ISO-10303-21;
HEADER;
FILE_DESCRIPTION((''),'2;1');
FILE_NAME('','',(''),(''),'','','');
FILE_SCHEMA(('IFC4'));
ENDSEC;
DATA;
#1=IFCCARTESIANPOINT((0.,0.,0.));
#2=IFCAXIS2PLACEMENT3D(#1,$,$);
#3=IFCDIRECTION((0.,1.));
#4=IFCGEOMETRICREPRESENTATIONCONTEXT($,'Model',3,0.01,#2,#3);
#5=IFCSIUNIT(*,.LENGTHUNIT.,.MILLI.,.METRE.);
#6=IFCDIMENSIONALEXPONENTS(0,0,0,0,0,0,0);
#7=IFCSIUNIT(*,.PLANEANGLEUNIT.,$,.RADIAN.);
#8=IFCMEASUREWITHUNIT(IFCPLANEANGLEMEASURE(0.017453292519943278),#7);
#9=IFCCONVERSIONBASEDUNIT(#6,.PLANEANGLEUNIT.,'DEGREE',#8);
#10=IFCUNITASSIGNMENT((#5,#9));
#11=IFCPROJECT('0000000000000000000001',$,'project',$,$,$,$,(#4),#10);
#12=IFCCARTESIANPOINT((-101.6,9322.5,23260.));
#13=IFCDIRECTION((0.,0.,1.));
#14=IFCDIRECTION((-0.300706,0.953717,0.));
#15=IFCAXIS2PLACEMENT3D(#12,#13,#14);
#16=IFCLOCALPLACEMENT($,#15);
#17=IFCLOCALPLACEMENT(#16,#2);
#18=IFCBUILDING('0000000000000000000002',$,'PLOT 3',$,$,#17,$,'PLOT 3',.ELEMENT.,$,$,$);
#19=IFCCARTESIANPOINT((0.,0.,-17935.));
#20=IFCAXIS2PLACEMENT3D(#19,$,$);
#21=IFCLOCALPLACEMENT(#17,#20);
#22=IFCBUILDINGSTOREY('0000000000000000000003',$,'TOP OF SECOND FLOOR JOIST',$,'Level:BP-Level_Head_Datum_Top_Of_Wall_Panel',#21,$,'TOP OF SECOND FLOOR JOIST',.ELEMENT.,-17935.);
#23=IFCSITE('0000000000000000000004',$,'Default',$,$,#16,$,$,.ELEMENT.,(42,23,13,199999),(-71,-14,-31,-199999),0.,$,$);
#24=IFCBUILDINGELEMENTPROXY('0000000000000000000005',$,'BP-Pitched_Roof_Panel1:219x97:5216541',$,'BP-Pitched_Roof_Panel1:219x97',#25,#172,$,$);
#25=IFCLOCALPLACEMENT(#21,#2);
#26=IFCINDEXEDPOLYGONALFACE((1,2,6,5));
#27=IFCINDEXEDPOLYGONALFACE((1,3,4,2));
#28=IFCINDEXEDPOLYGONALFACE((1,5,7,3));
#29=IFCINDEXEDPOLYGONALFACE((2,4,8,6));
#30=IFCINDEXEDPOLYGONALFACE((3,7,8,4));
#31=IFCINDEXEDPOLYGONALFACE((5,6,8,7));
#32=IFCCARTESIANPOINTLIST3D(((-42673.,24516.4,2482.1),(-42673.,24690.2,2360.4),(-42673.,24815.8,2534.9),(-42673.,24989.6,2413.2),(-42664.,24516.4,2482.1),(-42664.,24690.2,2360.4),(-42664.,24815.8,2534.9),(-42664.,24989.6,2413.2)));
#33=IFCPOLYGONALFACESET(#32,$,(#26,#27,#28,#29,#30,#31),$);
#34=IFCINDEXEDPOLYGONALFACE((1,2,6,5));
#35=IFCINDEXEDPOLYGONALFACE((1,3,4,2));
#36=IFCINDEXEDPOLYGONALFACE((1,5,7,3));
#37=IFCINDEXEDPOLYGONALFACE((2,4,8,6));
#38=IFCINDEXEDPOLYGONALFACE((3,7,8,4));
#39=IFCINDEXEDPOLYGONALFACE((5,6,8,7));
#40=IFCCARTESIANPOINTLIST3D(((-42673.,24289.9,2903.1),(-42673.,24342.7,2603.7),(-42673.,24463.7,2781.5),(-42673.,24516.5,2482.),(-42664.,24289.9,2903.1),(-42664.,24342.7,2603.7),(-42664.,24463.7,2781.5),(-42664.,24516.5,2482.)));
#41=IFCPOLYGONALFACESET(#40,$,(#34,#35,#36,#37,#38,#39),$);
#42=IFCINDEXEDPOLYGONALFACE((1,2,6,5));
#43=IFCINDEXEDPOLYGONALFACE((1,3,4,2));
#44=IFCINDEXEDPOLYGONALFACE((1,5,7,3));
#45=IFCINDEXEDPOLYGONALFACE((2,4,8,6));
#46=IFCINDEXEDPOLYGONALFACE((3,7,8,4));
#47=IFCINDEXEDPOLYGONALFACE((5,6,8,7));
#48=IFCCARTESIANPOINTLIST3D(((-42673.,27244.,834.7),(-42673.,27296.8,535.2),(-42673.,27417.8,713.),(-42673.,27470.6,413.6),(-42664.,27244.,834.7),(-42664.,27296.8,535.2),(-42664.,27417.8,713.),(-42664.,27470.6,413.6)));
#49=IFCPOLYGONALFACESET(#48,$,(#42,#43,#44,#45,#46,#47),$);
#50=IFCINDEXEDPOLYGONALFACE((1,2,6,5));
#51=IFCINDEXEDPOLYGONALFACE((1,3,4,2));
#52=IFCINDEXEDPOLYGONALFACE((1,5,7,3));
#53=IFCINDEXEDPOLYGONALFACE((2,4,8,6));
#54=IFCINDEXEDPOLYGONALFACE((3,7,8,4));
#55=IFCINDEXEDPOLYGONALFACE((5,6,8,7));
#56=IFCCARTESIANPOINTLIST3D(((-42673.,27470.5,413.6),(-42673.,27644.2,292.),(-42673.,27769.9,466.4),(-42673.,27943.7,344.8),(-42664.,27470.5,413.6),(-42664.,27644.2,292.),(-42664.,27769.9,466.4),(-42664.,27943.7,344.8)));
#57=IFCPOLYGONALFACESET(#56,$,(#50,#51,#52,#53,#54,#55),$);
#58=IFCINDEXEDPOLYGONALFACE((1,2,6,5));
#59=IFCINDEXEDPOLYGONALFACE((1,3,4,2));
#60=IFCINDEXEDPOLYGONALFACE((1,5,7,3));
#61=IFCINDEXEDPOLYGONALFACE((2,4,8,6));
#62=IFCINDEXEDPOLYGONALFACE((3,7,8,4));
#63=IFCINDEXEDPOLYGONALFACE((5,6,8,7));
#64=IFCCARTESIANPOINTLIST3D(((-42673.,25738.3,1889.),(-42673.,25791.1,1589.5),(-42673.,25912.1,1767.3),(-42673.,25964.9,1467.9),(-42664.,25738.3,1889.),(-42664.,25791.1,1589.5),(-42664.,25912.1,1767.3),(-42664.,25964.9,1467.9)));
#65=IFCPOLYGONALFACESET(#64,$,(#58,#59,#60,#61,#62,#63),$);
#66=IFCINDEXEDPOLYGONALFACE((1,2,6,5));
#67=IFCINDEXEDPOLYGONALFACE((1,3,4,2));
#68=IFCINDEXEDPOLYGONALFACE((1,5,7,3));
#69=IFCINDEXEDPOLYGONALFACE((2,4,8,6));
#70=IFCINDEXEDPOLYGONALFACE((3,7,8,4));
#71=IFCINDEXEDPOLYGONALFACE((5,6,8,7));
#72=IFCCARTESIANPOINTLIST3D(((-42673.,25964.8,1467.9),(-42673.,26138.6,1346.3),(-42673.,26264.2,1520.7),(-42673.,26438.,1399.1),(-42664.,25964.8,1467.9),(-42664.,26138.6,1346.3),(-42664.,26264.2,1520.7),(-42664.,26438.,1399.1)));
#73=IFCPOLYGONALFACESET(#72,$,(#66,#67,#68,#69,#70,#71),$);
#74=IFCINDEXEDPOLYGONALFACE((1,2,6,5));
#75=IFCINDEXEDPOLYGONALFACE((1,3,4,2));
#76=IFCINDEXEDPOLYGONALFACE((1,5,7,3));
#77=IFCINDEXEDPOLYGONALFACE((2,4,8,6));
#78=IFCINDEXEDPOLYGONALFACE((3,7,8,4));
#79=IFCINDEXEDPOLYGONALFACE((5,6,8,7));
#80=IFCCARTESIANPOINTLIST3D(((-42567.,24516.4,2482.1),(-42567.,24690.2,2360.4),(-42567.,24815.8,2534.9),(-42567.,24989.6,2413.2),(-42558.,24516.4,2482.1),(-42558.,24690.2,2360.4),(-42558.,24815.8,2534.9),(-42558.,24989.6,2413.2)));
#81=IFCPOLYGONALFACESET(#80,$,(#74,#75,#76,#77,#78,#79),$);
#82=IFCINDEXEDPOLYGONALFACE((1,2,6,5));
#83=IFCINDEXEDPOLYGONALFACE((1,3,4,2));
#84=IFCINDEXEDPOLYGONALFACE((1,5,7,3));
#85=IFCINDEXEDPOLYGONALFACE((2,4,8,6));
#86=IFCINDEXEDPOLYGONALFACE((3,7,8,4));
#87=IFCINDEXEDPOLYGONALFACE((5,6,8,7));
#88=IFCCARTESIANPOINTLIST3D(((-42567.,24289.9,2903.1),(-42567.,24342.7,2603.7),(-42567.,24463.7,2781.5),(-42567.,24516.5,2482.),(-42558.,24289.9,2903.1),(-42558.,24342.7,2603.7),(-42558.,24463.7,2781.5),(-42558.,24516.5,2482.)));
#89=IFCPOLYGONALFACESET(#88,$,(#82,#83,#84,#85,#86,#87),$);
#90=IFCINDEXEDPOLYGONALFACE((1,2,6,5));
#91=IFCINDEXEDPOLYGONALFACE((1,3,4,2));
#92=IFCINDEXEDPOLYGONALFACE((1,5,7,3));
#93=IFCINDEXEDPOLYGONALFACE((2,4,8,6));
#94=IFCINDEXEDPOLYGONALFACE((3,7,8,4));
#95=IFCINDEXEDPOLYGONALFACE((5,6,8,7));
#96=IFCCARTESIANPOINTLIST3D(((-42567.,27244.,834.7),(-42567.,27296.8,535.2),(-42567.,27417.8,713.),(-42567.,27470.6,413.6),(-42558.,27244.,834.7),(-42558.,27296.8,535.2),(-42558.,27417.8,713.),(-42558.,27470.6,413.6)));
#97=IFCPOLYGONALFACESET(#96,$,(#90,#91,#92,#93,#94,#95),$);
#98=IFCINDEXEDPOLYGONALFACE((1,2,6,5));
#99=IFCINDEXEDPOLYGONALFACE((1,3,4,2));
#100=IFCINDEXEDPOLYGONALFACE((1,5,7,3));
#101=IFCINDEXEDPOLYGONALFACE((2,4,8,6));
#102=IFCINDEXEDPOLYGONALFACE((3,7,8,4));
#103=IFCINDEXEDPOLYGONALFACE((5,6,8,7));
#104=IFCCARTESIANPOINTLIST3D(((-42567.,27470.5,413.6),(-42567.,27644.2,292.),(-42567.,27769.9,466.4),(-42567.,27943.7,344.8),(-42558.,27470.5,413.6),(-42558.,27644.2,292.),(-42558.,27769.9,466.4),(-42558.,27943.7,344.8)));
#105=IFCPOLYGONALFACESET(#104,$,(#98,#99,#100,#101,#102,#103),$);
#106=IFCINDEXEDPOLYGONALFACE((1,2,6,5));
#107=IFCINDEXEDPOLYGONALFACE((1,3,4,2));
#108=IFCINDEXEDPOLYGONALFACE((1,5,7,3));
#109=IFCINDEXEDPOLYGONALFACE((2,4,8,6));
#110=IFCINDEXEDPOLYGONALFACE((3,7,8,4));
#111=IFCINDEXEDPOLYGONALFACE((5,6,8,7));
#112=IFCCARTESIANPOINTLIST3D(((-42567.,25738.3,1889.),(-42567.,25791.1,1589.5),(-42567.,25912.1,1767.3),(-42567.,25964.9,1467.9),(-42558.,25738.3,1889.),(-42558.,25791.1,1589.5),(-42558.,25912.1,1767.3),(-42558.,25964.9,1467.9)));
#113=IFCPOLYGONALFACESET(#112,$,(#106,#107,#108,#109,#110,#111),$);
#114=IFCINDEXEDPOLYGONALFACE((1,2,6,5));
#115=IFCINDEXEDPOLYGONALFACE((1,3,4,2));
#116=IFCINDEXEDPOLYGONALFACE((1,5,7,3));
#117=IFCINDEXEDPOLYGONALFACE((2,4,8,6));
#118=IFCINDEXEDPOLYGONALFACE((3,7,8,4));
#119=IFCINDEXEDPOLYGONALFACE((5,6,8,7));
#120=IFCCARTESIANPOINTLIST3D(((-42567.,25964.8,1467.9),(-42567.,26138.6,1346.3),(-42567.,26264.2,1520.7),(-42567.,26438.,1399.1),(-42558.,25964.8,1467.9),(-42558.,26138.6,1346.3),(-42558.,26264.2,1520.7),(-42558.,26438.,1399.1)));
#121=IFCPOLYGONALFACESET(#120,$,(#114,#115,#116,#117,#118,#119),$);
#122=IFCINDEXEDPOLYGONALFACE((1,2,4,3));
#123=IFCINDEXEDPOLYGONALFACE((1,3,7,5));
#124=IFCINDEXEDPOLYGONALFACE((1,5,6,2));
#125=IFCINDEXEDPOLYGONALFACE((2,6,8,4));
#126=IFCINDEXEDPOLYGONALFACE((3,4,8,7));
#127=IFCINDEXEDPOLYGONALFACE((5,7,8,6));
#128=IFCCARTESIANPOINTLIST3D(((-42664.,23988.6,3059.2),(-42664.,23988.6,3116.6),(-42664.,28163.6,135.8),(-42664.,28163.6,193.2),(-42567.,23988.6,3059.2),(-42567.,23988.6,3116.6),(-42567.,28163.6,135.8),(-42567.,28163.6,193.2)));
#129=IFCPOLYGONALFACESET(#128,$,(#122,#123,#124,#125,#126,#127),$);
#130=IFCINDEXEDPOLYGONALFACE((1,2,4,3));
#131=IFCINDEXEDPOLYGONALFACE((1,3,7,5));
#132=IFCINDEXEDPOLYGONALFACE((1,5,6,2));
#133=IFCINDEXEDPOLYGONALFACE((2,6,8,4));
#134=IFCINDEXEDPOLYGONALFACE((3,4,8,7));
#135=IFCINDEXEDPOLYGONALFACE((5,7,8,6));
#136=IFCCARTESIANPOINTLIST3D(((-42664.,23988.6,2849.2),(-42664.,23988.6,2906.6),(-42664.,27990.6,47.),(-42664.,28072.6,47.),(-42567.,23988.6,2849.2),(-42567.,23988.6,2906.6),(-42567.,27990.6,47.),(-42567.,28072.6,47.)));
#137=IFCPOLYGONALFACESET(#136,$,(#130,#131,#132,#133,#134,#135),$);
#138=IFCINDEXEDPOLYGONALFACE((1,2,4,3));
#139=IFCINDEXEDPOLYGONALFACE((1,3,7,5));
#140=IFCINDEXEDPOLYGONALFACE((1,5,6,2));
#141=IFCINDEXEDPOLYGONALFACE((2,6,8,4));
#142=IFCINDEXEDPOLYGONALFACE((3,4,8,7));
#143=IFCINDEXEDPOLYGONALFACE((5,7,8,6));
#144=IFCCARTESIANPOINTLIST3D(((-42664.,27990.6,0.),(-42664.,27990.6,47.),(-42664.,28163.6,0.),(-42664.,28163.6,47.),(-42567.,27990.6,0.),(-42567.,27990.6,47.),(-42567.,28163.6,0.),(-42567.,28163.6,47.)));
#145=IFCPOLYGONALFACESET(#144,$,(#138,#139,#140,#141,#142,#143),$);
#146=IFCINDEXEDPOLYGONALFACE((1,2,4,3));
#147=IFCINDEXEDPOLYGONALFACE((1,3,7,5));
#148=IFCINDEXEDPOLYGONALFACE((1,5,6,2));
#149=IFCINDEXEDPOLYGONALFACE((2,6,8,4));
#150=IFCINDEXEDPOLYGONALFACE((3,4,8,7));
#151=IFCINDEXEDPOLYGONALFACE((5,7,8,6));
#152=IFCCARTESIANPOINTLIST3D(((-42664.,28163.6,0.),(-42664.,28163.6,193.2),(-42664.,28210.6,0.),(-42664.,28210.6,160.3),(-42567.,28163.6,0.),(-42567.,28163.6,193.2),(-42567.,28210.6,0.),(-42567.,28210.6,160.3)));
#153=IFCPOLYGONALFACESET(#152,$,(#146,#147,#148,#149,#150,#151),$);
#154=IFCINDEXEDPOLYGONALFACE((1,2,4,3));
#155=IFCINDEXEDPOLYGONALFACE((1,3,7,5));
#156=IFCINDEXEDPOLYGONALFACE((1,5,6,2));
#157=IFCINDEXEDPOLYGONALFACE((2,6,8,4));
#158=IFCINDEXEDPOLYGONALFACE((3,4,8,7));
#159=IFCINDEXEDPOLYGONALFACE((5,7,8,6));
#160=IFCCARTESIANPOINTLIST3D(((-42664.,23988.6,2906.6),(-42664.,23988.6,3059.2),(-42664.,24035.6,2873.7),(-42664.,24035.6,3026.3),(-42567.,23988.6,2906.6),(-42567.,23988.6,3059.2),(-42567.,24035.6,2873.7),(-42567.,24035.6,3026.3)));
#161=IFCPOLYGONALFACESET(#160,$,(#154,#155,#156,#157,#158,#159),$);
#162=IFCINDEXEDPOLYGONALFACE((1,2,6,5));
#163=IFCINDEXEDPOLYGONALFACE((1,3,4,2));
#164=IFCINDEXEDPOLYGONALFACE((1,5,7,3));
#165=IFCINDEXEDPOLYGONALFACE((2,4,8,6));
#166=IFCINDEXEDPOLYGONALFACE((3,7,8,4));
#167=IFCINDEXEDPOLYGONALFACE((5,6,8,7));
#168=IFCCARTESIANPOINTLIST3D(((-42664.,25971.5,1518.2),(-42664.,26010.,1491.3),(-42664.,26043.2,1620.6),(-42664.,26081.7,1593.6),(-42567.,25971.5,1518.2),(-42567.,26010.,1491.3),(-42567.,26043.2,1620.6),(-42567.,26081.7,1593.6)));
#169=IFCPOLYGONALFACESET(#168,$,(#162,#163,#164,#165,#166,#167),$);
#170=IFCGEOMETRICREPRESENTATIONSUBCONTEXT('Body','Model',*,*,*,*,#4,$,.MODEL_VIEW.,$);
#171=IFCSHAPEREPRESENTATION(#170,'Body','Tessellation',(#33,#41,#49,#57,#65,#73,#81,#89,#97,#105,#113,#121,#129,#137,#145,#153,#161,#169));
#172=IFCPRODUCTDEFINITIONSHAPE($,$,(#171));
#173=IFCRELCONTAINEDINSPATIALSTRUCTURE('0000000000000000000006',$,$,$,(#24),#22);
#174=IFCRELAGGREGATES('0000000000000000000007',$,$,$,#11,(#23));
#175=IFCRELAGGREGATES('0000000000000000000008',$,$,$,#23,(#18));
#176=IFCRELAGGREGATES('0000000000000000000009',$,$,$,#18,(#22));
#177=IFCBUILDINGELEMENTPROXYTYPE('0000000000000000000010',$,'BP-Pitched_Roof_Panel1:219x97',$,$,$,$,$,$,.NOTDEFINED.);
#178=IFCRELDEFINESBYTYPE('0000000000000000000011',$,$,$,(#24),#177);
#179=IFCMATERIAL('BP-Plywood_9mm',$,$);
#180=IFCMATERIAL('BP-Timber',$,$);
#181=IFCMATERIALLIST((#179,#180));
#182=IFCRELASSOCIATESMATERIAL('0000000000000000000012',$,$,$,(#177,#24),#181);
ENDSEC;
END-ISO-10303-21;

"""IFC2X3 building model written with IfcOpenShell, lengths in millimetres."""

from ifc_helpers import new_model, entity, si_unit, converted_unit, direction, frame, frame_2d, origin, origin_2d_with_axis, place, context, subcontext, project, spatial, polyline, rectangle, outline, extrude, source, transform, mapped, material, material_list, type_object, type_shapes, element, save


model = new_model("IFC2X3")

# Units and contexts
model_context = context("Model", 3, precision=0.01, world=origin(), true_north=direction((0.0, 1.0)))
body_context = subcontext(model_context, "Body", "Model", "MODEL_VIEW")
ifc_project = project(units=[si_unit("LENGTHUNIT", "METRE", prefix="MILLI"), converted_unit("PLANEANGLEUNIT", "DEGREE", entity("IfcPlaneAngleMeasure", 0.017453292519943278), si_unit("PLANEANGLEUNIT", "RADIAN"), dimensions=[0, 0, 0, 0, 0, 0, 0])], contexts=[model_context])

# Site, building, storey
site_placement = place(None, frame((-101.6, 9322.5, 23260.0), z_axis=(0.0, 0.0, 1.0), x_axis=(-0.300706, 0.953717, 0.0)))
site = spatial("IfcSite", under=ifc_project, at=site_placement, Name="Default", CompositionType="ELEMENT", RefLatitude=(42, 23, 13, 199999), RefLongitude=(-71, -14, -31, -199999), RefElevation=0.0)
building_placement = place(site_placement, origin())
building = spatial("IfcBuilding", under=site, at=building_placement, Name="PLOT 3", LongName="PLOT 3", CompositionType="ELEMENT")
storey_placement = place(building_placement, frame((0.0, 0.0, -17935.0)))
storey = spatial("IfcBuildingStorey", under=building, at=storey_placement, Name="TOP OF SECOND FLOOR JOIST", ObjectType="Level:BP-Level_Head_Datum_Top_Of_Wall_Panel", LongName="TOP OF SECOND FLOOR JOIST", CompositionType="ELEMENT", Elevation=-17935.0)

# Building element proxy
ifc_material_1 = material(Name="BP-Timber")
ifc_material_2 = material(Name="BP-Plywood_9mm")
ifc_material_list = material_list([ifc_material_2, ifc_material_1])
building_element_proxy_type_1 = type_object("IfcBuildingElementProxyType", Name="BP-Pitched_Roof_Panel1:219x97", PredefinedType="NOTDEFINED", material=ifc_material_list)
shared_shape_1 = source(origin(), body_context, "Body", "SweptSolid", [
    extrude(outline(polyline([(-77.0, -75.0), (227.0, -75.0), (77.0, 75.0), (-227.0, 75.0), (-77.0, -75.0)])), frame((35.3, -3956.0, 2447.7), z_axis=(0.0, 1.0, 0.0), x_axis=(-0.984808, 0.0, 0.173648)), (0.0, 0.0, 1.0), 9.0),
    extrude(outline(polyline([(1.4, -107.5), (213.6, -107.5), (-1.4, 107.5), (-213.6, 107.5), (1.4, -107.5)])), frame((385.1, -3956.0, 2692.6), z_axis=(0.0, 1.0, 0.0), x_axis=(-0.819152, 0.0, -0.573576)), (0.0, 0.0, 1.0), 9.0),
    extrude(outline(polyline([(1.4, -107.5), (213.6, -107.5), (-1.4, 107.5), (-213.6, 107.5), (1.4, -107.5)])), frame((-2569.0, -3956.0, 624.1), z_axis=(0.0, 1.0, 0.0), x_axis=(-0.819152, 0.0, -0.573576)), (0.0, 0.0, 1.0), 9.0),
    extrude(outline(polyline([(-77.0, -75.0), (227.0, -75.0), (77.0, 75.0), (-227.0, 75.0), (-77.0, -75.0)])), frame((-2918.8, -3956.0, 379.2), z_axis=(0.0, 1.0, 0.0), x_axis=(-0.984808, 0.0, 0.173648)), (0.0, 0.0, 1.0), 9.0),
    extrude(outline(polyline([(1.4, -107.5), (213.6, -107.5), (-1.4, 107.5), (-213.6, 107.5), (1.4, -107.5)])), frame((-1063.3, -3956.0, 1678.4), z_axis=(0.0, 1.0, 0.0), x_axis=(-0.819152, 0.0, -0.573576)), (0.0, 0.0, 1.0), 9.0),
    extrude(outline(polyline([(-77.0, -75.0), (227.0, -75.0), (77.0, 75.0), (-227.0, 75.0), (-77.0, -75.0)])), frame((-1413.1, -3956.0, 1433.5), z_axis=(0.0, 1.0, 0.0), x_axis=(-0.984808, 0.0, 0.173648)), (0.0, 0.0, 1.0), 9.0),
    extrude(outline(polyline([(-77.0, -75.0), (227.0, -75.0), (77.0, 75.0), (-227.0, 75.0), (-77.0, -75.0)])), frame((35.3, -3850.0, 2447.7), z_axis=(0.0, 1.0, 0.0), x_axis=(-0.984808, 0.0, 0.173648)), (0.0, 0.0, 1.0), 9.0),
    extrude(outline(polyline([(1.4, -107.5), (213.6, -107.5), (-1.4, 107.5), (-213.6, 107.5), (1.4, -107.5)])), frame((385.1, -3850.0, 2692.6), z_axis=(0.0, 1.0, 0.0), x_axis=(-0.819152, 0.0, -0.573576)), (0.0, 0.0, 1.0), 9.0),
    extrude(outline(polyline([(1.4, -107.5), (213.6, -107.5), (-1.4, 107.5), (-213.6, 107.5), (1.4, -107.5)])), frame((-2569.0, -3850.0, 624.1), z_axis=(0.0, 1.0, 0.0), x_axis=(-0.819152, 0.0, -0.573576)), (0.0, 0.0, 1.0), 9.0),
    extrude(outline(polyline([(-77.0, -75.0), (227.0, -75.0), (77.0, 75.0), (-227.0, 75.0), (-77.0, -75.0)])), frame((-2918.8, -3850.0, 379.2), z_axis=(0.0, 1.0, 0.0), x_axis=(-0.984808, 0.0, 0.173648)), (0.0, 0.0, 1.0), 9.0),
    extrude(outline(polyline([(1.4, -107.5), (213.6, -107.5), (-1.4, 107.5), (-213.6, 107.5), (1.4, -107.5)])), frame((-1063.3, -3850.0, 1678.4), z_axis=(0.0, 1.0, 0.0), x_axis=(-0.819152, 0.0, -0.573576)), (0.0, 0.0, 1.0), 9.0),
    extrude(outline(polyline([(-77.0, -75.0), (227.0, -75.0), (77.0, 75.0), (-227.0, 75.0), (-77.0, -75.0)])), frame((-1413.1, -3850.0, 1433.5), z_axis=(0.0, 1.0, 0.0), x_axis=(-0.984808, 0.0, 0.173648)), (0.0, 0.0, 1.0), 9.0),
    extrude(outline(polyline([(-1490.4, -2087.5), (-1433.0, -2087.5), (1490.4, 2087.5), (1433.0, 2087.5), (-1490.4, -2087.5)])), frame((-1287.8, -3947.0, 1626.2), z_axis=(0.0, 1.0, 0.0), x_axis=(0.0, 0.0, -1.0)), (0.0, 0.0, 1.0), 97.0),
    extrude(outline(polyline([(-1444.1, -2021.5), (-1386.8, -2021.5), (1415.5, 1980.5), (1415.5, 2062.5), (-1444.1, -2021.5)])), frame((-1221.8, -3947.0, 1462.5), z_axis=(0.0, 1.0, 0.0), x_axis=(0.0, 0.0, -1.0)), (0.0, 0.0, 1.0), 97.0),
    extrude(rectangle(XDim=173.0, YDim=97.0, at=origin_2d_with_axis()), frame((-3288.8, -3898.5, 0.0), z_axis=(0.0, 0.0, 1.0), x_axis=(-1.0, 0.0, 0.0)), (0.0, 0.0, 1.0), 47.0),
    extrude(outline(polyline([(22.0, -72.4), (79.4, -72.4), (-31.4, 85.9), (-69.9, 58.9), (22.0, -72.4)])), frame((-3398.8, -3947.0, 88.4), z_axis=(0.0, 1.0, 0.0), x_axis=(0.819152, 0.0, 0.573576)), (0.0, 0.0, 1.0), 97.0),
    extrude(outline(polyline([(15.1, -62.5), (72.5, -62.5), (-15.1, 62.5), (-72.5, 62.5), (15.1, -62.5)])), frame((776.2, -3947.0, 2966.5), z_axis=(0.0, 1.0, 0.0), x_axis=(0.819152, 0.0, 0.573576)), (0.0, 0.0, 1.0), 97.0),
    extrude(rectangle(XDim=47.0, YDim=97.0, at=frame_2d((0.0, 0.0), x_axis=(1.0, 0.0))), frame((-1202.4, -3898.5, 1504.7), z_axis=(-0.573576, 0.0, 0.819152), x_axis=(-0.819152, 0.0, -0.573576)), (0.0, 0.0, 1.0), 125.0),
])
type_shapes(building_element_proxy_type_1, [shared_shape_1])
for number, where, z_axis, x_axis, name in (
    (1, (-38717.0, 24788.3, 0.0), (0.0, 0.0, 1.0), (0.0, -1.0, 0.0), "BP-Pitched_Roof_Panel1:219x97:5216541"),
):
    element("IfcBuildingElementProxy", number, at=place(storey_placement, frame(where, z_axis=z_axis, x_axis=x_axis)), inside=storey, type_object=building_element_proxy_type_1, material=ifc_material_list, Name=name, ObjectType="BP-Pitched_Roof_Panel1:219x97", context=body_context, shape_type="MappedRepresentation", body=[
        mapped(shared_shape_1, transform((0.0, 0.0, 0.0), scale=1.0)),
    ])

save(model, "model.ifc")
